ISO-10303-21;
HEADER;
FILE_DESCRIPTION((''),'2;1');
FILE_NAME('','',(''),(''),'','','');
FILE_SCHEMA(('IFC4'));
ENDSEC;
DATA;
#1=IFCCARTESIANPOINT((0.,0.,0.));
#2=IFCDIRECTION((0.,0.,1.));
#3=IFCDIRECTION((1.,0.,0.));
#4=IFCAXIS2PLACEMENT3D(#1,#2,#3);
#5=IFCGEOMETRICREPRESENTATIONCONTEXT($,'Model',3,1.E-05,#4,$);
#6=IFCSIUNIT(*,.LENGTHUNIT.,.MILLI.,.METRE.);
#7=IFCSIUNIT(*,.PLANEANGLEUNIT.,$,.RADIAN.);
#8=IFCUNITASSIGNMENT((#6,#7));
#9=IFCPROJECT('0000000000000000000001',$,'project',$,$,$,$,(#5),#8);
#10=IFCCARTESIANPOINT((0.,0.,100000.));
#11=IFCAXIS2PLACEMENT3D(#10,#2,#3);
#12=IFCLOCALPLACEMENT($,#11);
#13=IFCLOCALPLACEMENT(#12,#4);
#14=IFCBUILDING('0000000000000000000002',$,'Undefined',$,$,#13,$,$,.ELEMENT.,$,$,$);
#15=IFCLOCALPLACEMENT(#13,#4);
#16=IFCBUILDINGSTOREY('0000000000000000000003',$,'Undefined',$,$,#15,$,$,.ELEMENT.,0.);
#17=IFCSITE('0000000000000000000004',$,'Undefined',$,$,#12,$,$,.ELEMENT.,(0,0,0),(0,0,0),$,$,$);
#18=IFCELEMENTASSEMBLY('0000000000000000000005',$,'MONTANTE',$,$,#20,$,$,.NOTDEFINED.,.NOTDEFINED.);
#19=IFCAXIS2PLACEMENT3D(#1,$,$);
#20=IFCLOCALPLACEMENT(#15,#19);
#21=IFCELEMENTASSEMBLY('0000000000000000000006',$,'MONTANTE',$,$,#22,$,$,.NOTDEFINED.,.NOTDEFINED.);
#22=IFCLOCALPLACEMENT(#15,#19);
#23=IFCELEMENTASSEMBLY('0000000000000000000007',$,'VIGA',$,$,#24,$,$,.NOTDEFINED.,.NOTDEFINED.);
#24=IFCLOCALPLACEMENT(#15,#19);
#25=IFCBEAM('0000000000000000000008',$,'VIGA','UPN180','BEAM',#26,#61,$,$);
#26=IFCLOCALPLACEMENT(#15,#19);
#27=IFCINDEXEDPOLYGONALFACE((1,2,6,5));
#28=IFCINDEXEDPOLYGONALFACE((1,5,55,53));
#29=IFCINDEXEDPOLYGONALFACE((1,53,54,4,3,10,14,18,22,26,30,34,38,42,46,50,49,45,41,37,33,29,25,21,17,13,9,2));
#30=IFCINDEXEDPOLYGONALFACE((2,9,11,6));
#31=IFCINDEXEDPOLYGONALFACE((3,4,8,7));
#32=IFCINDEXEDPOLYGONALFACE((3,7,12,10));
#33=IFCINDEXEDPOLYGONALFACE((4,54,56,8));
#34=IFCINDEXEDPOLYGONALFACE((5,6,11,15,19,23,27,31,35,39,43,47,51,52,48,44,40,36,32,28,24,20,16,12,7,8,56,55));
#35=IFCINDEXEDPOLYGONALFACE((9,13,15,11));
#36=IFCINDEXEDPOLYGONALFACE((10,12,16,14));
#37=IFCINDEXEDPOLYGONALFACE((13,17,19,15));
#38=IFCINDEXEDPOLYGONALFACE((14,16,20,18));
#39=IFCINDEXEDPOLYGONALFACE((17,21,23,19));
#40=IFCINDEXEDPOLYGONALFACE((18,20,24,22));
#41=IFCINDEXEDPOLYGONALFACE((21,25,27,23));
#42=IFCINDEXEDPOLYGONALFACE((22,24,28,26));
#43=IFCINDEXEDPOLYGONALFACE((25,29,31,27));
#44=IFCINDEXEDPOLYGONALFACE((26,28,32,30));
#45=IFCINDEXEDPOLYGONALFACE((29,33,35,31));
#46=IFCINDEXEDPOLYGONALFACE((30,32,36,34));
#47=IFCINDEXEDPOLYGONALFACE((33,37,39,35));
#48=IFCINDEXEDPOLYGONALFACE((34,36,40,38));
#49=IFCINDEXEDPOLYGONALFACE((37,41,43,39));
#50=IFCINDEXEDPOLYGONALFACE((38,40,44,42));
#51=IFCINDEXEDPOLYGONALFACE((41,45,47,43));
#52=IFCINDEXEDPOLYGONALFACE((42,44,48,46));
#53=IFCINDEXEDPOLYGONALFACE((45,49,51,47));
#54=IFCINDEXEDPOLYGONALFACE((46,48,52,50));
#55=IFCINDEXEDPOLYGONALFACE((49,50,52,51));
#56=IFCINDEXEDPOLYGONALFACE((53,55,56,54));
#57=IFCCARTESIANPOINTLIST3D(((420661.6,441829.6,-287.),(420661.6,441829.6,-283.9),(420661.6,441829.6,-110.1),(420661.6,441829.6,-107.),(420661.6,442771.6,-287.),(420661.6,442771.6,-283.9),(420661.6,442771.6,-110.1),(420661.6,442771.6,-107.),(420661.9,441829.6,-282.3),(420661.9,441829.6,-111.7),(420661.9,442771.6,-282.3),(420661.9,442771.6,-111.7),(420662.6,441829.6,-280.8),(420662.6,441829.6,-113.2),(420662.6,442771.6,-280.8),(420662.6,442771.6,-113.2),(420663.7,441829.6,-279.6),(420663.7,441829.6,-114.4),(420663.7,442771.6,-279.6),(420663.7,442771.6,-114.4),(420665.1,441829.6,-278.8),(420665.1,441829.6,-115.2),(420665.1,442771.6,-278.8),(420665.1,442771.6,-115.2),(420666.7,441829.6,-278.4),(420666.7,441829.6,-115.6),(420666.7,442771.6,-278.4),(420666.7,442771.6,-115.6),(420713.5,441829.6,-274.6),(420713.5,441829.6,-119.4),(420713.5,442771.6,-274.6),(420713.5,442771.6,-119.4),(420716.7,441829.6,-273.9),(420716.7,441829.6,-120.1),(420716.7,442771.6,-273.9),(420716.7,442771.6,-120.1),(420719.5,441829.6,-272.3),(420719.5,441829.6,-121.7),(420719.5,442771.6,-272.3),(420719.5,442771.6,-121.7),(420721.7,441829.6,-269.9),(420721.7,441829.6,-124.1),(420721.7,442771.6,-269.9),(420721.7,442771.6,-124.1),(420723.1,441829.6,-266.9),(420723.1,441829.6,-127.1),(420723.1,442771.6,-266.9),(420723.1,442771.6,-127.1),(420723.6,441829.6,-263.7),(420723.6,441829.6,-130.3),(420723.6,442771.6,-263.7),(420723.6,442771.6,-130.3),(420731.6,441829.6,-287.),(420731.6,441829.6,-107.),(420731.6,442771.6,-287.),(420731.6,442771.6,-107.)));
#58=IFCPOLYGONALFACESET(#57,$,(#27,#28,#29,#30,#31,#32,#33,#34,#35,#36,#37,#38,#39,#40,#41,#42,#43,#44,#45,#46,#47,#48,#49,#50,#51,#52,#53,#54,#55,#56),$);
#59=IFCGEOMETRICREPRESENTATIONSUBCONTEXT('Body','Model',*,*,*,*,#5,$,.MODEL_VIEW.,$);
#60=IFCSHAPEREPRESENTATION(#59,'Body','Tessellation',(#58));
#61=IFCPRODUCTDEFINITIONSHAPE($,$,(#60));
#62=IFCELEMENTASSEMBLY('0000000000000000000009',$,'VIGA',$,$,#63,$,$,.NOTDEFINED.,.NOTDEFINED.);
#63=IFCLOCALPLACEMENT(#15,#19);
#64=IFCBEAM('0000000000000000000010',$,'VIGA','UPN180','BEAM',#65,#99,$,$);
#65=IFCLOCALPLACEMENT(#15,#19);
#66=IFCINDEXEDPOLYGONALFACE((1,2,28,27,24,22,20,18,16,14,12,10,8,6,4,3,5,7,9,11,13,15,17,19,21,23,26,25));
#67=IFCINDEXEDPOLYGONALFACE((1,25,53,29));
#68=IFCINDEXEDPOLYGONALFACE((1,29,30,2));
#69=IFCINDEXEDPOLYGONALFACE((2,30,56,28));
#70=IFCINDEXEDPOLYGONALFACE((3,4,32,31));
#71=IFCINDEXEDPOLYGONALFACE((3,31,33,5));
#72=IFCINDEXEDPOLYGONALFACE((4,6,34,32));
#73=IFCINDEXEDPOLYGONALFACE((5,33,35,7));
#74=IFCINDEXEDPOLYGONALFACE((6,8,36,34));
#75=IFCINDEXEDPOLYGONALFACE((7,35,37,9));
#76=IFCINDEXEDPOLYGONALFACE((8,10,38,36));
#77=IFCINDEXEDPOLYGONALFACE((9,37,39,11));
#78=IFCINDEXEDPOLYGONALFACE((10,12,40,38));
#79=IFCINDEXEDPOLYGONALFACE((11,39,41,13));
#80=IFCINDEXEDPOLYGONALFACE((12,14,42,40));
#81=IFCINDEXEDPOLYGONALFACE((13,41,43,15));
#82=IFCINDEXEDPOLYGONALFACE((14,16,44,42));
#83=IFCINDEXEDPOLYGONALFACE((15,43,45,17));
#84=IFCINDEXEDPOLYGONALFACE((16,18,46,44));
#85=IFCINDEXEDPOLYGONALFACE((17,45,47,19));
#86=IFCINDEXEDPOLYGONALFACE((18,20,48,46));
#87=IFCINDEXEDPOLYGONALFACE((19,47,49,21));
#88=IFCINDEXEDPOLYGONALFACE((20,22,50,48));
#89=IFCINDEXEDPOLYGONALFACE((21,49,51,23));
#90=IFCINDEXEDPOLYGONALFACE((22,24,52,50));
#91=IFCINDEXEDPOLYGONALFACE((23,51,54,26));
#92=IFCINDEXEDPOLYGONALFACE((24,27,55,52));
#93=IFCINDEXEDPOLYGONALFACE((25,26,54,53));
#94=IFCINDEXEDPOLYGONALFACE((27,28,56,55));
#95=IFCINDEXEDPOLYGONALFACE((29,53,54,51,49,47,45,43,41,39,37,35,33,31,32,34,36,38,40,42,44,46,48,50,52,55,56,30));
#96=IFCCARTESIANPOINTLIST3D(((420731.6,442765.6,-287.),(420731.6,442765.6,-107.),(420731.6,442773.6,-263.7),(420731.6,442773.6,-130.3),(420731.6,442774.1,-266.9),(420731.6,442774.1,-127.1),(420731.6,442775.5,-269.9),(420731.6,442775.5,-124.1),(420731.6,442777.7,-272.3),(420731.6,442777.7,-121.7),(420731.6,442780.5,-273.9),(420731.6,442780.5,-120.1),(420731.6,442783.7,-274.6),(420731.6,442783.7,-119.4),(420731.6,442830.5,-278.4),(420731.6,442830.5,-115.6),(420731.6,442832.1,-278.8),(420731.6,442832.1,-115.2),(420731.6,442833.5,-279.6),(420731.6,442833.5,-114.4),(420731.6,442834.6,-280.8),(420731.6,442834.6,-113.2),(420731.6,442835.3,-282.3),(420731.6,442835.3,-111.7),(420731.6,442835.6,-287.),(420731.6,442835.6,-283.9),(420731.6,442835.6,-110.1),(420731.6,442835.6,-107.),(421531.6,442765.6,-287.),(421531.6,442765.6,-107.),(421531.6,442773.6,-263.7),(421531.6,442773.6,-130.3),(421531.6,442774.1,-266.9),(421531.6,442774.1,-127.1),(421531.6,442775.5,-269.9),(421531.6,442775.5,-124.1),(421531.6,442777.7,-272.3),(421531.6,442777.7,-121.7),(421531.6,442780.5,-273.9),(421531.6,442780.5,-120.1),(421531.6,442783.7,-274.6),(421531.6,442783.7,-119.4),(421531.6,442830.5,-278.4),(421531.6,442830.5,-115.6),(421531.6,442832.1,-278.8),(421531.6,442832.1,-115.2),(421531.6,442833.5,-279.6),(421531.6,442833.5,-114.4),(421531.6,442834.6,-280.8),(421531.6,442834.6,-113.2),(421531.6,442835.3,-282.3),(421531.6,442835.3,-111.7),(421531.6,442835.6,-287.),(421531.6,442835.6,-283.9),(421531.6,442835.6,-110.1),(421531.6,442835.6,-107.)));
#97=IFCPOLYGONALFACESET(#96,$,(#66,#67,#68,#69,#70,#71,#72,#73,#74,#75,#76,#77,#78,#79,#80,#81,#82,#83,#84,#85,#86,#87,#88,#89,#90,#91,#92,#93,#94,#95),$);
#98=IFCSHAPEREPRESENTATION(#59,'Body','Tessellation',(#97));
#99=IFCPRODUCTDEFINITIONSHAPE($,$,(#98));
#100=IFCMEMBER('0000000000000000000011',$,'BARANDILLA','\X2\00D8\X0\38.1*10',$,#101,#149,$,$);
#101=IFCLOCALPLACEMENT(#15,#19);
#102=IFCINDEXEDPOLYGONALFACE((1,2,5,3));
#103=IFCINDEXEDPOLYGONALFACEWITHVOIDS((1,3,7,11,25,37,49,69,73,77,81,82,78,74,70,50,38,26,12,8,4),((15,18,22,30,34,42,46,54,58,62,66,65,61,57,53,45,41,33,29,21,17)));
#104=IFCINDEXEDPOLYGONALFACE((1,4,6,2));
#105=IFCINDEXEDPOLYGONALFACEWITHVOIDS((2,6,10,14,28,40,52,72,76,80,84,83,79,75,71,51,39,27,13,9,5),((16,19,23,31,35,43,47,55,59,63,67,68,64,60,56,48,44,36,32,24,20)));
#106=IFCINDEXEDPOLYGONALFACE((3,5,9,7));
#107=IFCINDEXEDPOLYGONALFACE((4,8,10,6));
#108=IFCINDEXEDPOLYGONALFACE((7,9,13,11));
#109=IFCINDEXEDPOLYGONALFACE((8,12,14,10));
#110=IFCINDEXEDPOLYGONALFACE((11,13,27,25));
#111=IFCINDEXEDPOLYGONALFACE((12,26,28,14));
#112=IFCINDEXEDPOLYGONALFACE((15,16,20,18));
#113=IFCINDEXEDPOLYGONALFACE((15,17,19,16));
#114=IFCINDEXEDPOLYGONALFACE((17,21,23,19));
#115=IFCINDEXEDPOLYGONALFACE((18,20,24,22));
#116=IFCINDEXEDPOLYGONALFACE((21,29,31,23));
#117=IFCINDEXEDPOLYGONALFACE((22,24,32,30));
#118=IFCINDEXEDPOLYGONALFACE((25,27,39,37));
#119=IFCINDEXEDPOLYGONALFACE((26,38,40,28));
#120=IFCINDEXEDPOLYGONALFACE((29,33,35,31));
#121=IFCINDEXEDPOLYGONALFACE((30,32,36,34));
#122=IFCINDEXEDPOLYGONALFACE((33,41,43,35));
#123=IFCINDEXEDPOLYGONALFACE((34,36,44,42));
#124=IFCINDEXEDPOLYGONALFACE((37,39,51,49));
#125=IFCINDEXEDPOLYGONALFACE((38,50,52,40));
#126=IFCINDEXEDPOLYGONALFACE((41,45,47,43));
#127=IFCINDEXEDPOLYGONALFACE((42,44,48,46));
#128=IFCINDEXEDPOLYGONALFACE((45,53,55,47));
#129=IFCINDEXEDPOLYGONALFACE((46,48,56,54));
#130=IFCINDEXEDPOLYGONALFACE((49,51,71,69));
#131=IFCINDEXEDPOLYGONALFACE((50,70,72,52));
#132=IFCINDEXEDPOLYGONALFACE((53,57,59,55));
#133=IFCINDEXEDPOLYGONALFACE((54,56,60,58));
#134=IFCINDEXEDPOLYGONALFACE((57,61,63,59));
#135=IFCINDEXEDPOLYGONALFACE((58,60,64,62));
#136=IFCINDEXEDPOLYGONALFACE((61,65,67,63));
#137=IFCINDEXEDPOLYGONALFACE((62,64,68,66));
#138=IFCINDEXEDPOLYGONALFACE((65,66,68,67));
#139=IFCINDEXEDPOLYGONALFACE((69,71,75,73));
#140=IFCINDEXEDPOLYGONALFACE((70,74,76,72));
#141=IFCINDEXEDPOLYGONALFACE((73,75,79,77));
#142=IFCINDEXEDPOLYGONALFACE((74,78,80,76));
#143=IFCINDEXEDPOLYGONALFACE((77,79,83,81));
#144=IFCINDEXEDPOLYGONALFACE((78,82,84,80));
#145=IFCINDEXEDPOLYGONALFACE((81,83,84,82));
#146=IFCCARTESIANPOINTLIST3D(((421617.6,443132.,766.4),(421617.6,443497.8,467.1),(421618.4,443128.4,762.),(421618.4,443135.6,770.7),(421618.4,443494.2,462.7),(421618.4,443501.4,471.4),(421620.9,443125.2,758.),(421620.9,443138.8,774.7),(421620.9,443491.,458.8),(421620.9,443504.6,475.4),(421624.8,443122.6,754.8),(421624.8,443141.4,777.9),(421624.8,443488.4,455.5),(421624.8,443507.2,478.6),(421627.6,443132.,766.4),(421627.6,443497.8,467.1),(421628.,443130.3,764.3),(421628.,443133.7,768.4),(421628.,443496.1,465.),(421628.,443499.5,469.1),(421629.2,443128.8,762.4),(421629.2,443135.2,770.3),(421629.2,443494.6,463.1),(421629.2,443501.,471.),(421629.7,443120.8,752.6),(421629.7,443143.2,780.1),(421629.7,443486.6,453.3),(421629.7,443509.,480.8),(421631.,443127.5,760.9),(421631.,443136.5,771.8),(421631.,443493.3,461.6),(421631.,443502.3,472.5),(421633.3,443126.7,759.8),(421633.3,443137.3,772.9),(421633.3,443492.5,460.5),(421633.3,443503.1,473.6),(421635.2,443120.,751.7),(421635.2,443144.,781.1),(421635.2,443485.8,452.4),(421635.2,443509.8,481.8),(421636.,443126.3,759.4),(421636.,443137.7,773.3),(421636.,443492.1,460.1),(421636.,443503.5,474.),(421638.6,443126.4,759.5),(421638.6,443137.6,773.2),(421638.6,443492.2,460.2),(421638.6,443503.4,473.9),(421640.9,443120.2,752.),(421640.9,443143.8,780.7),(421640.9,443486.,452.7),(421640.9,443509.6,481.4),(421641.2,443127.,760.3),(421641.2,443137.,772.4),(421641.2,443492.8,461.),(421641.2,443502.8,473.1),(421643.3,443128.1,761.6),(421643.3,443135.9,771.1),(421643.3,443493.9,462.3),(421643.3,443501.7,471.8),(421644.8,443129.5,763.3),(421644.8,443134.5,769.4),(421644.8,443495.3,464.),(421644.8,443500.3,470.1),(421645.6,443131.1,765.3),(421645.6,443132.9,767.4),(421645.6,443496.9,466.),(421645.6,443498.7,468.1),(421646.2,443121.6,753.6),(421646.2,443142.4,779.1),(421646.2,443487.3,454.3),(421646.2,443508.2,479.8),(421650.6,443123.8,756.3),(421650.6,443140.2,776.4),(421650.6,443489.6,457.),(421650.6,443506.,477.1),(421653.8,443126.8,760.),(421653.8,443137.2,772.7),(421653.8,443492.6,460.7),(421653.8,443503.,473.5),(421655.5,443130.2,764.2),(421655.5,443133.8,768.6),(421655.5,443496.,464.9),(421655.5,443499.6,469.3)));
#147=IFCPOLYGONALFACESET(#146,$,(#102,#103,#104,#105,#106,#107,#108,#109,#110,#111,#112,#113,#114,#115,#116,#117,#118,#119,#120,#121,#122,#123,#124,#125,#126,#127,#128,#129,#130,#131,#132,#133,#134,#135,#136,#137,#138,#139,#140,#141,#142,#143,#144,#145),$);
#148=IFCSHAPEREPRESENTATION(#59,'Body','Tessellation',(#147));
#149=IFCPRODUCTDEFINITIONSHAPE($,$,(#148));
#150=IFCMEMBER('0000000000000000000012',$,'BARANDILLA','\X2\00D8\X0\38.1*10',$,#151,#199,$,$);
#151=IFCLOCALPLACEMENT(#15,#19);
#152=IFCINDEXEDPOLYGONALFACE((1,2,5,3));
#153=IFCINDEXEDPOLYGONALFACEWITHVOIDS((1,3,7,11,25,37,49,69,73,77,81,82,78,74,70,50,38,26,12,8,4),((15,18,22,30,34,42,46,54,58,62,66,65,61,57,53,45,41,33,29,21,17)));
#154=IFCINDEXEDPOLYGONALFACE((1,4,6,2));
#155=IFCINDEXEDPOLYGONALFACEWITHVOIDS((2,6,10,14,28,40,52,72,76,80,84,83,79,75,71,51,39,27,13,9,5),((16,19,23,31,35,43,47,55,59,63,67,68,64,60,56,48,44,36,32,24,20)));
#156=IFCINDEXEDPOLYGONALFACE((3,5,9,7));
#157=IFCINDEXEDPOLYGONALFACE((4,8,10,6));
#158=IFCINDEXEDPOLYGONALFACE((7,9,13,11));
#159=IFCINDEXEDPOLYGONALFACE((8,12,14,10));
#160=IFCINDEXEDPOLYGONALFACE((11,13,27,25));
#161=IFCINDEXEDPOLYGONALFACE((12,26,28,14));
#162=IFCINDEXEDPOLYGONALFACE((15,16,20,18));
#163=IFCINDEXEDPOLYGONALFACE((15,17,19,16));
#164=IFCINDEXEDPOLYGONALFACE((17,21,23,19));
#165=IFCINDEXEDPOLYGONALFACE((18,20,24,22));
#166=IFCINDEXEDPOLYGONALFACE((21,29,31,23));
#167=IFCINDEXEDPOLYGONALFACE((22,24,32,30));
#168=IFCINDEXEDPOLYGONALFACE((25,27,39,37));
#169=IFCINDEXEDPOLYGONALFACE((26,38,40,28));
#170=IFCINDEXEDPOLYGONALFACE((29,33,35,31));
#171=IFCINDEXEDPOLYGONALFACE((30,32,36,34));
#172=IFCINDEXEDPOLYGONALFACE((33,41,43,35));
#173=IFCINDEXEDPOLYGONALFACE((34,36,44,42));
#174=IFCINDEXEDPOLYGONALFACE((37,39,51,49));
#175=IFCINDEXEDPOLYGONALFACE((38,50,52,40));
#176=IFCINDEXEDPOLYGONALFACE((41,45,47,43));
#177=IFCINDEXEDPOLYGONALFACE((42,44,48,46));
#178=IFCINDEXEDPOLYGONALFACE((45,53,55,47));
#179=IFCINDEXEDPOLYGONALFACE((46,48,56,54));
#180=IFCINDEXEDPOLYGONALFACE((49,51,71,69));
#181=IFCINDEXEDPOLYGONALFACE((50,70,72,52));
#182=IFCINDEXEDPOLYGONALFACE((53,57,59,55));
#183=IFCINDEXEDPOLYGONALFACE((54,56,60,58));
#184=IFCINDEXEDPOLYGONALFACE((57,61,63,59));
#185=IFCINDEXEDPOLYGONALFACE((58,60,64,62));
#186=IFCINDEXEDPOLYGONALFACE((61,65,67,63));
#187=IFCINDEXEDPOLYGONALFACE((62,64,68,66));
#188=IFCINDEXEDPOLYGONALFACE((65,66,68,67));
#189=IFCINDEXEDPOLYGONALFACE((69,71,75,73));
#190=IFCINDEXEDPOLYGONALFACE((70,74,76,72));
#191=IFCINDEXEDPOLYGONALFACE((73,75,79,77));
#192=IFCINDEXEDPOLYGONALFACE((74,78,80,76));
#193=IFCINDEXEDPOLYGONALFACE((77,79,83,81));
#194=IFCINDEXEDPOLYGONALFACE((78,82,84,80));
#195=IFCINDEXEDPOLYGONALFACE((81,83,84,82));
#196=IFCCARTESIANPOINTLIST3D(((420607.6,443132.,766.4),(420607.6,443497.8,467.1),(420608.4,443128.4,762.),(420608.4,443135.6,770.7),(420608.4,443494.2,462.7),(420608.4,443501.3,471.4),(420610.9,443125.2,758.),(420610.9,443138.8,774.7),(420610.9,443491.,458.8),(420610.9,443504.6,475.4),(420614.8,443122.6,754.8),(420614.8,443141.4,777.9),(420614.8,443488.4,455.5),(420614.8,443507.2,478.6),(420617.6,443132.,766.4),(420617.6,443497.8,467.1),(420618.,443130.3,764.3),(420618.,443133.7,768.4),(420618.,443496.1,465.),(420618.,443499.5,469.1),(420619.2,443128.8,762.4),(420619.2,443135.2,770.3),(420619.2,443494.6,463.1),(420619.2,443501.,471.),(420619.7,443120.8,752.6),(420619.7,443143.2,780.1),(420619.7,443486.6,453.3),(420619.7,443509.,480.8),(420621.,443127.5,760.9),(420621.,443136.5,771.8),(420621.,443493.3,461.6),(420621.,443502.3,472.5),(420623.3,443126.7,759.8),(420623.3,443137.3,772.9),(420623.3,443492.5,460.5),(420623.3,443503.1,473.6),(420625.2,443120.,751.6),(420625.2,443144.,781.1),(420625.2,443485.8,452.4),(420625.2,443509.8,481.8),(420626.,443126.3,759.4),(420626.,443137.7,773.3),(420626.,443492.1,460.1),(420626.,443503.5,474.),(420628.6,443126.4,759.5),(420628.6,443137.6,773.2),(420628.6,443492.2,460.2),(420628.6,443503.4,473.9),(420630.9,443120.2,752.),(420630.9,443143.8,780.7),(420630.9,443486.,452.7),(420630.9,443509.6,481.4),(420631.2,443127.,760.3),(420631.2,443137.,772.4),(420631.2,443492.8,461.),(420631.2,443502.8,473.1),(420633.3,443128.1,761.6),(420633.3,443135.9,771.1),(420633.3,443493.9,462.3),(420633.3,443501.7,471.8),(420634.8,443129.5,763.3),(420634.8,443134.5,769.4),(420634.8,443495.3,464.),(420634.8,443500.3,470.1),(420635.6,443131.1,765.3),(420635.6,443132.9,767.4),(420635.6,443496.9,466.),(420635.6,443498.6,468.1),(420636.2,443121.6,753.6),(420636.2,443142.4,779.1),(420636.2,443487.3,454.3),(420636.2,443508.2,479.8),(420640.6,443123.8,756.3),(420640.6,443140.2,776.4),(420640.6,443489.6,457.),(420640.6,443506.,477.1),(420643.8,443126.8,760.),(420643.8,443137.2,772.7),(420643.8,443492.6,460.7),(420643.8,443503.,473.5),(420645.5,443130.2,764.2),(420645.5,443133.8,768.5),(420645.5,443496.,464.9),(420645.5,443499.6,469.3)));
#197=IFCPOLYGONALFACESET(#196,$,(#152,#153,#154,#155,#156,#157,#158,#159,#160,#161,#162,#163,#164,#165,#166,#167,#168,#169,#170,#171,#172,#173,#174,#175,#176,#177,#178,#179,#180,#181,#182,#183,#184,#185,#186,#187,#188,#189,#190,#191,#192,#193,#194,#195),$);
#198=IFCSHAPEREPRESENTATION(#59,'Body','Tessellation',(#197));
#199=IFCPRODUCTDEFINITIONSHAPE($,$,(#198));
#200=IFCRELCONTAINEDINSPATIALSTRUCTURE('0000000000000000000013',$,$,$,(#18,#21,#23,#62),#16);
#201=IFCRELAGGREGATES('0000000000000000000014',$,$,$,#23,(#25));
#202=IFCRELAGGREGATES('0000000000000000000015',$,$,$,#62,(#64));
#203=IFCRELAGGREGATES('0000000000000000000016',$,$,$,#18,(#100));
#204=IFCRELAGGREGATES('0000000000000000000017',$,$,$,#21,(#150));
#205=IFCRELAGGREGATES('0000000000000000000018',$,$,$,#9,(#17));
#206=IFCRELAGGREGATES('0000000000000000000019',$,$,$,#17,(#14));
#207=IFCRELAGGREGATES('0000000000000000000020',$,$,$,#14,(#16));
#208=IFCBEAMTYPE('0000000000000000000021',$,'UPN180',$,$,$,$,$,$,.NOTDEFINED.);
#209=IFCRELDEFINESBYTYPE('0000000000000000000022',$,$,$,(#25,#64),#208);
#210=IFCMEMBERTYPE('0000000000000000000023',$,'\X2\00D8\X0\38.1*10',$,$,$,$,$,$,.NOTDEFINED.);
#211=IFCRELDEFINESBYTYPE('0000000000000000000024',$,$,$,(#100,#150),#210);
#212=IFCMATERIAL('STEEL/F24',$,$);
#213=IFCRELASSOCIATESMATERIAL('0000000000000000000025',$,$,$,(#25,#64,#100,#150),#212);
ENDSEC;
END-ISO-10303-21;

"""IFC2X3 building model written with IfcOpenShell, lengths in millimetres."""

from ifc_helpers import new_model, si_unit, frame, origin_with_axes, origin_2d_with_axis, place, context, subcontext, project, spatial, hollow_circle, u_section, extrude, clip, halfspace, material, type_object, element, aggregate, save


model = new_model("IFC2X3")

# Units and contexts
model_context = context("Model", 3, precision=1e-05, world=origin_with_axes())
body_context = subcontext(model_context, "Body", "Model", "MODEL_VIEW")
ifc_project = project(units=[si_unit("LENGTHUNIT", "METRE", prefix="MILLI"), si_unit("PLANEANGLEUNIT", "RADIAN")], contexts=[model_context])

# Site, building, storey
site_placement = place(None, frame((0.0, 0.0, 100000.0), z_axis=(0.0, 0.0, 1.0), x_axis=(1.0, 0.0, 0.0)))
site = spatial("IfcSite", under=ifc_project, at=site_placement, Name="Undefined", CompositionType="ELEMENT", RefLatitude=(0, 0, 0), RefLongitude=(0, 0, 0))
building_placement = place(site_placement, origin_with_axes())
building = spatial("IfcBuilding", under=site, at=building_placement, Name="Undefined", CompositionType="ELEMENT")
storey_placement = place(building_placement, origin_with_axes())
storey = spatial("IfcBuildingStorey", under=building, at=storey_placement, Name="Undefined", CompositionType="ELEMENT", Elevation=0.0)

# Shared definitions
ifc_material_1 = material(Name="STEEL/F24")

# Element assemblies
assembly_1_placement = place(storey_placement, origin_with_axes())
assembly_1 = element("IfcElementAssembly", 1, at=assembly_1_placement, inside=storey, Name="MONTANTE", AssemblyPlace="NOTDEFINED", PredefinedType="NOTDEFINED")
assembly_2_placement = place(storey_placement, origin_with_axes())
assembly_2 = element("IfcElementAssembly", 2, at=assembly_2_placement, inside=storey, Name="MONTANTE", AssemblyPlace="NOTDEFINED", PredefinedType="NOTDEFINED")

# Element assemblies, beams
beam_type_1 = type_object("IfcBeamType", Name="UPN180", PredefinedType="NOTDEFINED")
assembly_3_placement = place(storey_placement, origin_with_axes())
assembly_3 = element("IfcElementAssembly", 3, at=assembly_3_placement, inside=storey, Name="VIGA", AssemblyPlace="NOTDEFINED", PredefinedType="NOTDEFINED")
beam_1_placement = place(assembly_3_placement, frame((420696.6, 442771.6, -197.0), z_axis=(0.0, 0.0, 1.0), x_axis=(0.0, -1.0, 0.0)))
beam_1 = element("IfcBeam", 4, at=beam_1_placement, type_object=beam_type_1, material=ifc_material_1, Name="VIGA", Description="UPN180", ObjectType="BEAM", context=body_context, shape_type="SweptSolid", body=[
    extrude(u_section(Depth=180.0, FlangeWidth=70.0, WebThickness=8.0, FlangeThickness=11.0, FilletRadius=11.0, EdgeRadius=5.5, FlangeSlope=0.07983, at=origin_2d_with_axis()), frame((941.9, 0.0, 0.0), z_axis=(-1.0, 0.0, 0.0), x_axis=(0.0, -1.0, 0.0)), (0.0, 0.0, 1.0), 942.0),
])
aggregate(assembly_3, [beam_1])
assembly_4_placement = place(storey_placement, origin_with_axes())
assembly_4 = element("IfcElementAssembly", 5, at=assembly_4_placement, inside=storey, Name="VIGA", AssemblyPlace="NOTDEFINED", PredefinedType="NOTDEFINED")
beam_2_placement = place(assembly_4_placement, frame((421531.6, 442800.6, -197.0), z_axis=(0.0, 0.0, 1.0), x_axis=(-1.0, 0.0, 0.0)))
beam_2 = element("IfcBeam", 6, at=beam_2_placement, type_object=beam_type_1, material=ifc_material_1, Name="VIGA", Description="UPN180", ObjectType="BEAM", context=body_context, shape_type="SweptSolid", body=[
    extrude(u_section(Depth=180.0, FlangeWidth=70.0, WebThickness=8.0, FlangeThickness=11.0, FilletRadius=11.0, EdgeRadius=5.5, FlangeSlope=0.07983, at=origin_2d_with_axis()), frame((800.0, 0.0, 0.0), z_axis=(-1.0, 0.0, 0.0), x_axis=(0.0, -1.0, 0.0)), (0.0, 0.0, 1.0), 800.0),
])
aggregate(assembly_4, [beam_2])

# Members
member_type_1 = type_object("IfcMemberType", Name="Ø38.1*10", PredefinedType="NOTDEFINED")
member_1_placement = place(assembly_1_placement, frame((421636.6, 443132.0, 766.4), z_axis=(0.000001, -0.633238, -0.773957), x_axis=(-0.000001, 0.773957, -0.633238)))
member_1 = element("IfcMember", 7, at=member_1_placement, type_object=member_type_1, material=ifc_material_1, Name="BARANDILLA", Description="Ø38.1*10", context=body_context, shape_type="Clipping", body=[
    clip(clip(extrude(hollow_circle(Radius=19.1, WallThickness=10.0, at=origin_2d_with_axis()), frame((510.4, 0.0, 0.0), z_axis=(-1.0, 0.0, 0.0), x_axis=(0.0, -1.0, 0.0)), (0.0, 0.0, 1.0), 548.1), halfspace(frame((472.6, 0.0, 0.0), z_axis=(1.0, 0.0, 0.0), x_axis=(0.0, -1.0, 0.0)), False)), halfspace(frame((0.0, 0.0, 0.0), z_axis=(1.0, 0.0, 0.0), x_axis=(0.0, -1.0, 0.0)), True)),
])
member_2_placement = place(assembly_2_placement, frame((420626.6, 443132.0, 766.4), z_axis=(0.000001, -0.633238, -0.773957), x_axis=(-0.000001, 0.773957, -0.633238)))
member_2 = element("IfcMember", 8, at=member_2_placement, type_object=member_type_1, material=ifc_material_1, Name="BARANDILLA", Description="Ø38.1*10", context=body_context, shape_type="Clipping", body=[
    clip(clip(extrude(hollow_circle(Radius=19.1, WallThickness=10.0, at=origin_2d_with_axis()), frame((510.3, 0.0, 0.0), z_axis=(-1.0, 0.0, 0.0), x_axis=(0.0, -1.0, 0.0)), (0.0, 0.0, 1.0), 548.1), halfspace(frame((472.6, 0.0, 0.0), z_axis=(1.0, 0.0, 0.0), x_axis=(0.0, -1.0, 0.0)), False)), halfspace(frame((0.0, 0.0, 0.0), z_axis=(1.0, 0.0, 0.0), x_axis=(0.0, -1.0, 0.0)), True)),
])
aggregate(assembly_1, [member_1])
aggregate(assembly_2, [member_2])

save(model, "model.ifc")
